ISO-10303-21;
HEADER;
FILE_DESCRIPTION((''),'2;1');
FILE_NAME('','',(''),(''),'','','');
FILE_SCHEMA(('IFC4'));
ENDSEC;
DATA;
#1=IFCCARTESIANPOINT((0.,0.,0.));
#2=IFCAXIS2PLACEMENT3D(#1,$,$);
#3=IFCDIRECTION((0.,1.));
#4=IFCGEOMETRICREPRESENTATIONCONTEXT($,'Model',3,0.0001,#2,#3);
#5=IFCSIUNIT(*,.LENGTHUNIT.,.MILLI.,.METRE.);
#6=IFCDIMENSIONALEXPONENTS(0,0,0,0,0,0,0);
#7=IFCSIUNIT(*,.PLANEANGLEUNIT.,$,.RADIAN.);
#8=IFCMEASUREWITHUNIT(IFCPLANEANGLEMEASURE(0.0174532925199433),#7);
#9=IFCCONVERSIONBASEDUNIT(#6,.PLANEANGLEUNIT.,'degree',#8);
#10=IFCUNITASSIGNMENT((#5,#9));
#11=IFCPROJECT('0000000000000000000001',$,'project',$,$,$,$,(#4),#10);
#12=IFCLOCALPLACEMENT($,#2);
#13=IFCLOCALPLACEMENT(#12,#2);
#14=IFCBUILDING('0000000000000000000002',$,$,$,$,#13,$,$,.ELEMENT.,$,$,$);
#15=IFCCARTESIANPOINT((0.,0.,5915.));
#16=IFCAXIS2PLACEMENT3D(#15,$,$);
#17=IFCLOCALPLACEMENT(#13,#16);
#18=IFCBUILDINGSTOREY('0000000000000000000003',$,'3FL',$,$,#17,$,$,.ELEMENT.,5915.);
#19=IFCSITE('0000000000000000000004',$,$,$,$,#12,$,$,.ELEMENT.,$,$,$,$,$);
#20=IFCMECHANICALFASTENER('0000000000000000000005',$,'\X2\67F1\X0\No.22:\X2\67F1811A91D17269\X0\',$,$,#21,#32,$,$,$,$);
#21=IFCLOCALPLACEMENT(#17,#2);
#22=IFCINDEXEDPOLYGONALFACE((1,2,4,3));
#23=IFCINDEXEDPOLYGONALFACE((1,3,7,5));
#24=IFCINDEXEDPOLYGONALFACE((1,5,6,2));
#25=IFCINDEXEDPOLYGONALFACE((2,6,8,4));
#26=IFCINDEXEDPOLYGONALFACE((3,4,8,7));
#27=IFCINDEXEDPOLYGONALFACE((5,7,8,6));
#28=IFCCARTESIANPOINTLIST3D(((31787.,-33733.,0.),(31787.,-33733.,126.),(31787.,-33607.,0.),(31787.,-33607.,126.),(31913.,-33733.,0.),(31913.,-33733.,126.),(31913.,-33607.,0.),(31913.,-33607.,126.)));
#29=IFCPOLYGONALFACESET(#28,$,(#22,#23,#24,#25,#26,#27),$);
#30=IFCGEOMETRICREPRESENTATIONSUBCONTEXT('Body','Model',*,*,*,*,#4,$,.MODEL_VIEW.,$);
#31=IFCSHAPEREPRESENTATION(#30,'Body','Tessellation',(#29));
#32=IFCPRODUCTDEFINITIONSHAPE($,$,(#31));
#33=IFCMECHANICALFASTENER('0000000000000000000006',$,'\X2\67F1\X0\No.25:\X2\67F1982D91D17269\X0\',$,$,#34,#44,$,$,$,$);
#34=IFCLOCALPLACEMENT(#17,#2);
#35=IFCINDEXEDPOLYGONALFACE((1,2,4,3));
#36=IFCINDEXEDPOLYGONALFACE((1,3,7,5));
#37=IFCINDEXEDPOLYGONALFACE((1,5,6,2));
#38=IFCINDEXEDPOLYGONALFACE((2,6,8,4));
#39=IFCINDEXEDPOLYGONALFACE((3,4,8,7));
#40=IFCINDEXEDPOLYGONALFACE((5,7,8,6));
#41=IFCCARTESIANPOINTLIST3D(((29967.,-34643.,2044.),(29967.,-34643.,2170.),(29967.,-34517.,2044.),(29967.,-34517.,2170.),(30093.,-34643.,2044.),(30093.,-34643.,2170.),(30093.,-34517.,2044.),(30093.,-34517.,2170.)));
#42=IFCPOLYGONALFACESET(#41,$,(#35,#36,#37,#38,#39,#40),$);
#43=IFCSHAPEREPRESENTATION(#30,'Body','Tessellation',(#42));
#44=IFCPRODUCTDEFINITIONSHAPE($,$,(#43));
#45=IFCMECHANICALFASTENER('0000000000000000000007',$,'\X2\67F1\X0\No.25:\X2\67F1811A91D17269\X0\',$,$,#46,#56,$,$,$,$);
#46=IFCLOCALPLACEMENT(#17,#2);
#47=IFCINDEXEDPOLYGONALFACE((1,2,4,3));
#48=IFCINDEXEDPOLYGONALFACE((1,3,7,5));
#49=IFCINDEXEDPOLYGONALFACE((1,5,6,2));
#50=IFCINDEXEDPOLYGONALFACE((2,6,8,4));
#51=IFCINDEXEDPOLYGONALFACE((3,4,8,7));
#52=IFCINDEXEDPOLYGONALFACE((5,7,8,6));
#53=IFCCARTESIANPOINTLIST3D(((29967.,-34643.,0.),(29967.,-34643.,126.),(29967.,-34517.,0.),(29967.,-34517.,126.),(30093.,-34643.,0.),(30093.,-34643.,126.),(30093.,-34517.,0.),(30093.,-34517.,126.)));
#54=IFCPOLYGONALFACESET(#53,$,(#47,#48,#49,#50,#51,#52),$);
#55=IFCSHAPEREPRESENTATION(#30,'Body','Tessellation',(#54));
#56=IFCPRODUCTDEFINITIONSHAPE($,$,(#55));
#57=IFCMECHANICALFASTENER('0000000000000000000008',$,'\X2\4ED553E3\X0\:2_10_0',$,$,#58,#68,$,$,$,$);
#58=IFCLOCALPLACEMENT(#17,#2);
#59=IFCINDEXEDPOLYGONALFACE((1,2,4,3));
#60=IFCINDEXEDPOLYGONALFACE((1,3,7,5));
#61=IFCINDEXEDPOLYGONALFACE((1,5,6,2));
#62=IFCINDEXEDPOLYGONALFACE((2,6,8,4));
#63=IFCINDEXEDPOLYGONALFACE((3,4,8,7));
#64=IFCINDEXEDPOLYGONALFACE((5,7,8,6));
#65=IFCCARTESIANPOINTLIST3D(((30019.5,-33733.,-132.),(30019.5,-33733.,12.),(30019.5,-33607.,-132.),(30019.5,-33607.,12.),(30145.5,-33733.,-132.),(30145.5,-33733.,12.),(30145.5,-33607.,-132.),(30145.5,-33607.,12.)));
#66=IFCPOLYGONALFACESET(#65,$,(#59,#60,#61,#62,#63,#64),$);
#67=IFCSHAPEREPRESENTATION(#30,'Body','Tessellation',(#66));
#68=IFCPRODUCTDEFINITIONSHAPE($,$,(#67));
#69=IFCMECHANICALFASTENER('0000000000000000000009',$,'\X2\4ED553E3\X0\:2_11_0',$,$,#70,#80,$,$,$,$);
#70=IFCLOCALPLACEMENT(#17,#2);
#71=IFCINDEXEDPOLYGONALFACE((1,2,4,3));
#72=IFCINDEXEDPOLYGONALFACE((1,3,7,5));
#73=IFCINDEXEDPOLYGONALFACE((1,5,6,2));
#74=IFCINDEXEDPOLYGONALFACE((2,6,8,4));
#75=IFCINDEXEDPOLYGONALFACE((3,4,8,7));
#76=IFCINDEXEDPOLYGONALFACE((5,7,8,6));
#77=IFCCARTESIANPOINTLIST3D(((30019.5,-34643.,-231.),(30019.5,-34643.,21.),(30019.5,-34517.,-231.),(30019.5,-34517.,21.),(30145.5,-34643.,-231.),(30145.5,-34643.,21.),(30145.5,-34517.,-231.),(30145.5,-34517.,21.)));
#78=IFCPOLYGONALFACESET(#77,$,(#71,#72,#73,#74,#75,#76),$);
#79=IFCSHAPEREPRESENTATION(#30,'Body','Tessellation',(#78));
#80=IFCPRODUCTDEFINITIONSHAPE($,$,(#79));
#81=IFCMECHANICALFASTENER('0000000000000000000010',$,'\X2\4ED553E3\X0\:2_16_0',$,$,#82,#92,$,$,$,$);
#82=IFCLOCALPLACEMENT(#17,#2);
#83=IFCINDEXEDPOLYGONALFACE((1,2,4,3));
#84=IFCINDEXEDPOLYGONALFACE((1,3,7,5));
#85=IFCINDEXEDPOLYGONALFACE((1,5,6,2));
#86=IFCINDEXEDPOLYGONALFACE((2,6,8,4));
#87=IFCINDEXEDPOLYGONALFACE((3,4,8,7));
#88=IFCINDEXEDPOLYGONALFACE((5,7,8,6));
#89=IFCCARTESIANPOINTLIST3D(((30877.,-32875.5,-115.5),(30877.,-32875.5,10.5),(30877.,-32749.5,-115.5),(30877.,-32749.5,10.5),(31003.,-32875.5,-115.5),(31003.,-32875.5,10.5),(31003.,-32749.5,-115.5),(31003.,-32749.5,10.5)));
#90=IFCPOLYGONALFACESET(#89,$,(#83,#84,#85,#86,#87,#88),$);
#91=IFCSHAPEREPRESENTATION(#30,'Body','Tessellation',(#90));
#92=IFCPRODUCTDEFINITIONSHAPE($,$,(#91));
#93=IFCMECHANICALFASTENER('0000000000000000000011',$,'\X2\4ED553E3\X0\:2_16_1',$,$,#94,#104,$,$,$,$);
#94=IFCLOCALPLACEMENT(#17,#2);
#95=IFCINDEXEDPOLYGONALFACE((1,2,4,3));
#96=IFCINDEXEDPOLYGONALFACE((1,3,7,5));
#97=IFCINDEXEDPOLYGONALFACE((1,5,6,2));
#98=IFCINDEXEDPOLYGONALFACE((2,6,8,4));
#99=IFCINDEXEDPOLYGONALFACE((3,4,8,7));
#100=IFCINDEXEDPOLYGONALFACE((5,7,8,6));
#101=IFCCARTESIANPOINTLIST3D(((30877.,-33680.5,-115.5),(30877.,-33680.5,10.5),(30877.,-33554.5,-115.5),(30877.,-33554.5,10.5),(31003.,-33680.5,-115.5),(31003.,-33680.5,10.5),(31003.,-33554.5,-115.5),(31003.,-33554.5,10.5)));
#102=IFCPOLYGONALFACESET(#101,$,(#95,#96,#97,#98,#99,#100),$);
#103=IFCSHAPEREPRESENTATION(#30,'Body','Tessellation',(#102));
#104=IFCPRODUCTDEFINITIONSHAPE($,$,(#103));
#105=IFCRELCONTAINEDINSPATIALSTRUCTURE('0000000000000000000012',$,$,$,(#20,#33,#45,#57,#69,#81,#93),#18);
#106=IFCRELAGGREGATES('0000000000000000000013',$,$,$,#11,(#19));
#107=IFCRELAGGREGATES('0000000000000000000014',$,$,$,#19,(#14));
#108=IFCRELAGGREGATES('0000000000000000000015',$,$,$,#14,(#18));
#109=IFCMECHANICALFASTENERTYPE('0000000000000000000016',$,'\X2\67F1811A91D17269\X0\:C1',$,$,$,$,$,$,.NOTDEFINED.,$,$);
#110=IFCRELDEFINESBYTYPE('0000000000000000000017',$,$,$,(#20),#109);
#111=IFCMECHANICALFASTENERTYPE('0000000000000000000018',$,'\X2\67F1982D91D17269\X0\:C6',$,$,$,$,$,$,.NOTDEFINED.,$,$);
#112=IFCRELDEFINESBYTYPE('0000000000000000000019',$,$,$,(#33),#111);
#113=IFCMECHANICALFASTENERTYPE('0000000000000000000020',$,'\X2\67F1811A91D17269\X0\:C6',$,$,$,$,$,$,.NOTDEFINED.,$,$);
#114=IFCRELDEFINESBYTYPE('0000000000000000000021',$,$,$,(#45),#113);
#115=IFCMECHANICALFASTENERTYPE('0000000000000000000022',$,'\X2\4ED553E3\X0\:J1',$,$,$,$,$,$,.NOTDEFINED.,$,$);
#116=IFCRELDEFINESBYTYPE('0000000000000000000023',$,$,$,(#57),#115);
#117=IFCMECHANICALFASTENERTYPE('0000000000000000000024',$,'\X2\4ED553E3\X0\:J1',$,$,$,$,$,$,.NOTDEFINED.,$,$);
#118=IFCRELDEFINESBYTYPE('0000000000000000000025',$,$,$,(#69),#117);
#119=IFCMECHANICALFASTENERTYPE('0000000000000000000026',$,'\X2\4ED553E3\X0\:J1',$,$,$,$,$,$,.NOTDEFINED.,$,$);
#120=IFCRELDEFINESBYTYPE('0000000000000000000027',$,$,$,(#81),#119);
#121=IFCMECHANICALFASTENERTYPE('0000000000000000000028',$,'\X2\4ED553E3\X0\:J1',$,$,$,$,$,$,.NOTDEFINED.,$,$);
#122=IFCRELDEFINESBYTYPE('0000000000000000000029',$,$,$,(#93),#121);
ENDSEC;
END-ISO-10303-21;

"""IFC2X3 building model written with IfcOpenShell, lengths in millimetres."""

from ifc_helpers import new_model, entity, si_unit, converted_unit, direction, frame, origin, origin_with_axes, origin_2d, place, context, subcontext, project, spatial, rectangle, extrude, type_object, element, save


model = new_model("IFC2X3")

# Units and contexts
model_context = context("Model", 3, precision=0.0001, world=origin(), true_north=direction((0.0, 1.0)))
body_context = subcontext(model_context, "Body", "Model", "MODEL_VIEW")
ifc_project = project(units=[si_unit("LENGTHUNIT", "METRE", prefix="MILLI"), converted_unit("PLANEANGLEUNIT", "degree", entity("IfcPlaneAngleMeasure", 0.0174532925199433), si_unit("PLANEANGLEUNIT", "RADIAN"), dimensions=[0, 0, 0, 0, 0, 0, 0])], contexts=[model_context])

# Site, building, storey
site_placement = place(None, origin())
site = spatial("IfcSite", under=ifc_project, at=site_placement, CompositionType="ELEMENT")
building_placement = place(site_placement, origin())
building = spatial("IfcBuilding", under=site, at=building_placement, CompositionType="ELEMENT")
storey_placement = place(building_placement, frame((0.0, 0.0, 5915.0)))
storey = spatial("IfcBuildingStorey", under=building, at=storey_placement, Name="3FL", CompositionType="ELEMENT", Elevation=5915.0)

# Mechanical fasteners
mechanical_fastener_type_1 = type_object("IfcMechanicalFastenerType", Name="柱脚金物:C1")
mechanical_fastener_1_placement = place(storey_placement, frame((31850.0, -33670.0, 0.0)))
element("IfcMechanicalFastener", 1, at=mechanical_fastener_1_placement, inside=storey, type_object=mechanical_fastener_type_1, Name="柱No.22:柱脚金物", context=body_context, shape_type="SweptSolid", body=[
    extrude(rectangle(XDim=126.0, YDim=126.0, at=origin_2d()), origin_with_axes(), (0.0, 0.0, 1.0), 126.0),
])
mechanical_fastener_type_2 = type_object("IfcMechanicalFastenerType", Name="柱頭金物:C6")
mechanical_fastener_2_placement = place(storey_placement, frame((30030.0, -34580.0, 2044.0)))
element("IfcMechanicalFastener", 2, at=mechanical_fastener_2_placement, inside=storey, type_object=mechanical_fastener_type_2, Name="柱No.25:柱頭金物", context=body_context, shape_type="SweptSolid", body=[
    extrude(rectangle(XDim=126.0, YDim=126.0, at=origin_2d()), origin_with_axes(), (0.0, 0.0, 1.0), 126.0),
])
mechanical_fastener_type_3 = type_object("IfcMechanicalFastenerType", Name="柱脚金物:C6")
mechanical_fastener_3_placement = place(storey_placement, frame((30030.0, -34580.0, 0.0)))
element("IfcMechanicalFastener", 3, at=mechanical_fastener_3_placement, inside=storey, type_object=mechanical_fastener_type_3, Name="柱No.25:柱脚金物", context=body_context, shape_type="SweptSolid", body=[
    extrude(rectangle(XDim=126.0, YDim=126.0, at=origin_2d()), origin_with_axes(), (0.0, 0.0, 1.0), 126.0),
])
mechanical_fastener_type_4 = type_object("IfcMechanicalFastenerType", Name="仕口:J1")
mechanical_fastener_4_placement = place(storey_placement, frame((30082.5, -33670.0, -132.0)))
element("IfcMechanicalFastener", 4, at=mechanical_fastener_4_placement, inside=storey, type_object=mechanical_fastener_type_4, Name="仕口:2_10_0", context=body_context, shape_type="SweptSolid", body=[
    extrude(rectangle(XDim=126.0, YDim=126.0, at=origin_2d()), origin_with_axes(), (0.0, 0.0, 1.0), 144.0),
])
mechanical_fastener_type_5 = type_object("IfcMechanicalFastenerType", Name="仕口:J1")
mechanical_fastener_5_placement = place(storey_placement, frame((30082.5, -34580.0, -231.0)))
element("IfcMechanicalFastener", 5, at=mechanical_fastener_5_placement, inside=storey, type_object=mechanical_fastener_type_5, Name="仕口:2_11_0", context=body_context, shape_type="SweptSolid", body=[
    extrude(rectangle(XDim=126.0, YDim=126.0, at=origin_2d()), origin_with_axes(), (0.0, 0.0, 1.0), 252.0),
])
mechanical_fastener_type_6 = type_object("IfcMechanicalFastenerType", Name="仕口:J1")
mechanical_fastener_6_placement = place(storey_placement, frame((30940.0, -32812.5, -115.5)))
element("IfcMechanicalFastener", 6, at=mechanical_fastener_6_placement, inside=storey, type_object=mechanical_fastener_type_6, Name="仕口:2_16_0", context=body_context, shape_type="SweptSolid", body=[
    extrude(rectangle(XDim=126.0, YDim=126.0, at=origin_2d()), origin_with_axes(), (0.0, 0.0, 1.0), 126.0),
])
mechanical_fastener_type_7 = type_object("IfcMechanicalFastenerType", Name="仕口:J1")
mechanical_fastener_7_placement = place(storey_placement, frame((30940.0, -33617.5, -115.5)))
element("IfcMechanicalFastener", 7, at=mechanical_fastener_7_placement, inside=storey, type_object=mechanical_fastener_type_7, Name="仕口:2_16_1", context=body_context, shape_type="SweptSolid", body=[
    extrude(rectangle(XDim=126.0, YDim=126.0, at=origin_2d()), origin_with_axes(), (0.0, 0.0, 1.0), 126.0),
])

save(model, "model.ifc")
